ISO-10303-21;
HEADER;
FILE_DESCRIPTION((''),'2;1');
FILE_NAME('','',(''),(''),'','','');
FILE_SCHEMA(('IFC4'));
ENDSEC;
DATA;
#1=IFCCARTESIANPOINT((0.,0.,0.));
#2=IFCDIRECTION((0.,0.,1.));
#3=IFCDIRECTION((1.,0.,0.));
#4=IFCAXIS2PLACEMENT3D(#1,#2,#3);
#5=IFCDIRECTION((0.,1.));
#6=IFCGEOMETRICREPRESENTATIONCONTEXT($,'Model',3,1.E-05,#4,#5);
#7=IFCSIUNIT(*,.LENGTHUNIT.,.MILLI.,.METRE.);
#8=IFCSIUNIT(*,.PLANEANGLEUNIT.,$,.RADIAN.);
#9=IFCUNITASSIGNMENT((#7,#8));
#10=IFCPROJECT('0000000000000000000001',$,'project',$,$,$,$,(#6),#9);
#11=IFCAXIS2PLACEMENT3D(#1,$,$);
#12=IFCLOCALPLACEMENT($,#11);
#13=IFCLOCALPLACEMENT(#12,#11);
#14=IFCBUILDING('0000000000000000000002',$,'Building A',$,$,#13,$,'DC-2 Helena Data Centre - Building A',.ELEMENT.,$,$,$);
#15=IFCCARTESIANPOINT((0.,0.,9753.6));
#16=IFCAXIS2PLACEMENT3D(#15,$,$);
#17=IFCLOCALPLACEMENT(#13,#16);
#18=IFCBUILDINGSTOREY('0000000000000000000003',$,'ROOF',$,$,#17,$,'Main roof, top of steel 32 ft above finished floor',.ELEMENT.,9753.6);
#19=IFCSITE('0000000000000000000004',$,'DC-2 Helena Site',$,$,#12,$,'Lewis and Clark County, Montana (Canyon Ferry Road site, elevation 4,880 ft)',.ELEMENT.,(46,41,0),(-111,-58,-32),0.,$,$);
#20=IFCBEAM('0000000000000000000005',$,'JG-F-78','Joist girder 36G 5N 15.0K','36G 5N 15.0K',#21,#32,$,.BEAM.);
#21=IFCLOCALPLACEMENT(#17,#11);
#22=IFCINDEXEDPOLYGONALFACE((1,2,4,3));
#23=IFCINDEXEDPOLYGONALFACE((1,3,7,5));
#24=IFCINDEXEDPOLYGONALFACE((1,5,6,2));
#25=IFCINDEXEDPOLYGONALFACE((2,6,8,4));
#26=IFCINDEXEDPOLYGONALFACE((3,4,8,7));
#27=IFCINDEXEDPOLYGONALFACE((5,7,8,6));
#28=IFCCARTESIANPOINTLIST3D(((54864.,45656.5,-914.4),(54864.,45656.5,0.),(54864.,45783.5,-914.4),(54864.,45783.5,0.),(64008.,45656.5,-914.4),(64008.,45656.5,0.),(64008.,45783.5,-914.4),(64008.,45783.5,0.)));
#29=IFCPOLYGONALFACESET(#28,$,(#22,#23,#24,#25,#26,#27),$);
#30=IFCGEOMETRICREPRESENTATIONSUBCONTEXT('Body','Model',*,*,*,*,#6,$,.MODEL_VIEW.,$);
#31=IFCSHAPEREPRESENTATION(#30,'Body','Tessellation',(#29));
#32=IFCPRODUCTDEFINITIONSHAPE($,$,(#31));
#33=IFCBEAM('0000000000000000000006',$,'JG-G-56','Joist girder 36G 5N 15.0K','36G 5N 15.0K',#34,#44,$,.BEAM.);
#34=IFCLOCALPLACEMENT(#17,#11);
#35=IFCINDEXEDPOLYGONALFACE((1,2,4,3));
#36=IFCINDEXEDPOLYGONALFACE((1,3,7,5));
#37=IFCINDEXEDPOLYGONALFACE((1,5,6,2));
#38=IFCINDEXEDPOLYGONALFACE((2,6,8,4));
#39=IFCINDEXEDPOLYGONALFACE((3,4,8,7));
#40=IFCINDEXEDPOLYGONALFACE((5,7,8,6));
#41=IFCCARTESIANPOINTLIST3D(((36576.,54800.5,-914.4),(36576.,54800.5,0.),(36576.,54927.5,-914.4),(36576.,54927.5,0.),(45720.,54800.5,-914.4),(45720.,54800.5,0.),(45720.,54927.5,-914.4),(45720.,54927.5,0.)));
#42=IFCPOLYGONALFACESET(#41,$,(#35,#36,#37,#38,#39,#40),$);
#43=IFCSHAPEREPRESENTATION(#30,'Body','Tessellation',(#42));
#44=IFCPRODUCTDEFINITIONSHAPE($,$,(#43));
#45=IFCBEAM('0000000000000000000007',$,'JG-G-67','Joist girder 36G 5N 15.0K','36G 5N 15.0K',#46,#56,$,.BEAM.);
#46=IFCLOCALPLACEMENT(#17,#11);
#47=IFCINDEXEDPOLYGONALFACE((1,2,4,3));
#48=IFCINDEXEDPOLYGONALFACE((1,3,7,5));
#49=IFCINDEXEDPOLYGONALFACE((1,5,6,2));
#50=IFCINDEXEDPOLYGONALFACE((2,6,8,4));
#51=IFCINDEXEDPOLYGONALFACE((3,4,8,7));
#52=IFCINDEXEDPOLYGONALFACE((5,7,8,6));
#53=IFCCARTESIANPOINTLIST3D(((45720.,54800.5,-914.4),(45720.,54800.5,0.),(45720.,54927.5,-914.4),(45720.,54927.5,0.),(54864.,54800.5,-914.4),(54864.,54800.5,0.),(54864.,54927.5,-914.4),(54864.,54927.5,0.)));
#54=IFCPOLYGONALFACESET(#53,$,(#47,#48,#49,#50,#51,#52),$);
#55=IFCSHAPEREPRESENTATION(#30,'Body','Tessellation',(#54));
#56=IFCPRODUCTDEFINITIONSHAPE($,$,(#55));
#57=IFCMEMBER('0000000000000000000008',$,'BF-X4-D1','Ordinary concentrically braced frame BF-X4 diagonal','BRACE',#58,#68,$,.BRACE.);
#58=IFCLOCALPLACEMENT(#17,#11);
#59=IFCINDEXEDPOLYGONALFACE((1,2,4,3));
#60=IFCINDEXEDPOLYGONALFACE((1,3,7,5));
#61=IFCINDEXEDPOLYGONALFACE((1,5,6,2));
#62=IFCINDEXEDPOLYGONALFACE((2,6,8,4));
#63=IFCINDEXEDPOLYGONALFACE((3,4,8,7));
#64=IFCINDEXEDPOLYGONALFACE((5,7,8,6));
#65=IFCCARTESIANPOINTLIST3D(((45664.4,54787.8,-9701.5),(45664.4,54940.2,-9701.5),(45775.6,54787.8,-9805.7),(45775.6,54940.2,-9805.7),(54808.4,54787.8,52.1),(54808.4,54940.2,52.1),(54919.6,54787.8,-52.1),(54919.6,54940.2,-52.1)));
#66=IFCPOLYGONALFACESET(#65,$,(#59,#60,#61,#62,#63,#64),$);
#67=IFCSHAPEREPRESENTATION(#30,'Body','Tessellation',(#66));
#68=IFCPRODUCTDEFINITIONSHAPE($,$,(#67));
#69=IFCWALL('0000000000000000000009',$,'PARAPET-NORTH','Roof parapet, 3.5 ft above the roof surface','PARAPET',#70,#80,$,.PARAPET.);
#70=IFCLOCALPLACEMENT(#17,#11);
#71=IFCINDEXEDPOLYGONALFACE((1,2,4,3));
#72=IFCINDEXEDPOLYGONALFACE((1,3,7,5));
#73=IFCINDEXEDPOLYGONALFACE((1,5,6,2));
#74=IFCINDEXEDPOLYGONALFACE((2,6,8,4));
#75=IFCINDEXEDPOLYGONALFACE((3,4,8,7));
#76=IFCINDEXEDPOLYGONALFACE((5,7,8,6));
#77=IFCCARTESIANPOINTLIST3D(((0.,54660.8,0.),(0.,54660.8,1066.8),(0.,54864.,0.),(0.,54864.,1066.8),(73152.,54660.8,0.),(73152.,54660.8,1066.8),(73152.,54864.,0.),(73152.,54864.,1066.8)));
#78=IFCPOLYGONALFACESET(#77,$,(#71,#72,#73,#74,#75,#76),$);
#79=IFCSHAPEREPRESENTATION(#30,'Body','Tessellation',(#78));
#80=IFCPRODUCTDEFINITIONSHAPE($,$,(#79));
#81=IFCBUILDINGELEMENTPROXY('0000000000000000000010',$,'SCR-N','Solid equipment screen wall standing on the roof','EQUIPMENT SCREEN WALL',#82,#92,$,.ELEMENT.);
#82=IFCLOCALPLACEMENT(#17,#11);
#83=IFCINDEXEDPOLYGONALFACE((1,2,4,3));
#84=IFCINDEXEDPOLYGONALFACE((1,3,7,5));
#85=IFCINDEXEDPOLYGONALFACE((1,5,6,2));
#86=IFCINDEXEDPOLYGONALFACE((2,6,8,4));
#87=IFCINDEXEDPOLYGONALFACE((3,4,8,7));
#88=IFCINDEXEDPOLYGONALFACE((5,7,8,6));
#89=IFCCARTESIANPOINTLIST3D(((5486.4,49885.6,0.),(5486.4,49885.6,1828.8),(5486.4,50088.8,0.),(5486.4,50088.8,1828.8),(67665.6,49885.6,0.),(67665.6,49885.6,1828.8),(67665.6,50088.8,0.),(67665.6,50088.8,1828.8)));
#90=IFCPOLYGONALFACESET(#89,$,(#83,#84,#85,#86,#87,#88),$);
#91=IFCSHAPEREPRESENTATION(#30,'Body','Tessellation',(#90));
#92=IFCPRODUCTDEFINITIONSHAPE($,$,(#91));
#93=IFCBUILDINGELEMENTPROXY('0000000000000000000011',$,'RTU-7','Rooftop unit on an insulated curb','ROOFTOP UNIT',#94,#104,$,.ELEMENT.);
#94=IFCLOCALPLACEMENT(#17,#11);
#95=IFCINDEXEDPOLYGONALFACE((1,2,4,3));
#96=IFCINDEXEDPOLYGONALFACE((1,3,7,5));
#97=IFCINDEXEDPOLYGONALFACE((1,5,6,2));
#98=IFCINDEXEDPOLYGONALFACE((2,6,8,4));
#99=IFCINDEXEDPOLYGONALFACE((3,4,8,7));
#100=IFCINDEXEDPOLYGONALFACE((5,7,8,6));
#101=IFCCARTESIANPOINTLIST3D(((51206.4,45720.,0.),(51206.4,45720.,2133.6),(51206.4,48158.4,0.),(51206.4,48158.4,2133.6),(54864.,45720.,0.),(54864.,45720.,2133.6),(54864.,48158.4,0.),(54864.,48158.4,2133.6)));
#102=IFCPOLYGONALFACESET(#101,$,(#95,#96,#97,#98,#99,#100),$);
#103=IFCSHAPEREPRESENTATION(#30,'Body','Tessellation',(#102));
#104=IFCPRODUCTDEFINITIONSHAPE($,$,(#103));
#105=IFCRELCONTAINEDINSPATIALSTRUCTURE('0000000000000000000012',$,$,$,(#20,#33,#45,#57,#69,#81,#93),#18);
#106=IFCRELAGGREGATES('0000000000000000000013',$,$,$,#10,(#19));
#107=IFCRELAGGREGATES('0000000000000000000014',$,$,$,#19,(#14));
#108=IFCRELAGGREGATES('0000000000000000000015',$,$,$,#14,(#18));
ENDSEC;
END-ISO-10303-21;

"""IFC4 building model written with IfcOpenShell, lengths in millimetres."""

from ifc_helpers import new_model, si_unit, direction, frame, origin, origin_with_axes, origin_2d, place, context, subcontext, project, spatial, rectangle, extrude, element, save


model = new_model("IFC4")

# Units and contexts
model_context = context("Model", 3, precision=1e-05, world=origin_with_axes(), true_north=direction((0.0, 1.0)))
body_context = subcontext(model_context, "Body", "Model", "MODEL_VIEW")
ifc_project = project(units=[si_unit("LENGTHUNIT", "METRE", prefix="MILLI"), si_unit("PLANEANGLEUNIT", "RADIAN")], contexts=[model_context])

# Site, building, storey
site_placement = place(None, origin())
site = spatial("IfcSite", under=ifc_project, at=site_placement, Name="DC-2 Helena Site", LongName="Lewis and Clark County, Montana (Canyon Ferry Road site, elevation 4,880 ft)", CompositionType="ELEMENT", RefLatitude=(46, 41, 0), RefLongitude=(-111, -58, -32), RefElevation=0.0)
building_placement = place(site_placement, origin())
building = spatial("IfcBuilding", under=site, at=building_placement, Name="Building A", LongName="DC-2 Helena Data Centre - Building A", CompositionType="ELEMENT")
storey_placement = place(building_placement, frame((0.0, 0.0, 9753.6)))
storey = spatial("IfcBuildingStorey", under=building, at=storey_placement, Name="ROOF", LongName="Main roof, top of steel 32 ft above finished floor", CompositionType="ELEMENT", Elevation=9753.6)

# Shared definitions
placement_1 = place(storey_placement, frame((45720.0, 54864.0, -9753.6)))

# Beams
placement_2 = place(storey_placement, frame((54864.0, 45720.0, 0.0)))
element("IfcBeam", 1, at=placement_2, inside=storey, Name="JG-F-78", Description="Joist girder 36G 5N 15.0K", ObjectType="36G 5N 15.0K", PredefinedType="BEAM", context=body_context, shape_type="SweptSolid", body=[
    extrude(rectangle(XDim=127.0, YDim=914.4, at=origin_2d()), frame((0.0, 0.0, -457.2), z_axis=(1.0, 0.0, 0.0), x_axis=(0.0, 1.0, 0.0)), (0.0, 0.0, 1.0), 9144.0),
])
for number, where, name in (
    (2, (36576.0, 54864.0, 0.0), "JG-G-56"),
    (3, (45720.0, 54864.0, 0.0), "JG-G-67"),
):
    element("IfcBeam", number, at=place(storey_placement, frame(where)), inside=storey, Name=name, Description="Joist girder 36G 5N 15.0K", ObjectType="36G 5N 15.0K", PredefinedType="BEAM", context=body_context, shape_type="SweptSolid", body=[
        extrude(rectangle(XDim=127.0, YDim=914.4, at=origin_2d()), frame((0.0, 0.0, -457.2), z_axis=(1.0, 0.0, 0.0), x_axis=(0.0, 1.0, 0.0)), (0.0, 0.0, 1.0), 9144.0),
    ])

# Member
element("IfcMember", 4, at=placement_1, inside=storey, Name="BF-X4-D1", Description="Ordinary concentrically braced frame BF-X4 diagonal", ObjectType="BRACE", PredefinedType="BRACE", context=body_context, shape_type="SweptSolid", body=[
    extrude(rectangle(XDim=152.4, YDim=152.4, at=origin_2d()), frame((0.0, 0.0, 0.0), z_axis=(0.683941, 0.0, 0.729537), x_axis=(0.0, 1.0, 0.0)), (0.0, 0.0, 1.0), 13369.6),
])

# Wall
wall_placement = place(storey_placement, frame((36576.0, 54762.4, 0.0)))
element("IfcWall", 5, at=wall_placement, inside=storey, Name="PARAPET-NORTH", Description="Roof parapet, 3.5 ft above the roof surface", ObjectType="PARAPET", PredefinedType="PARAPET", context=body_context, shape_type="SweptSolid", body=[
    extrude(rectangle(XDim=73152.0, YDim=203.2, at=origin_2d()), origin(), (0.0, 0.0, 1.0), 1066.8),
])

# Building element proxies
proxy_1_placement = place(storey_placement, frame((36576.0, 49987.2, 0.0)))
element("IfcBuildingElementProxy", 6, at=proxy_1_placement, inside=storey, Name="SCR-N", Description="Solid equipment screen wall standing on the roof", ObjectType="EQUIPMENT SCREEN WALL", PredefinedType="ELEMENT", context=body_context, shape_type="SweptSolid", body=[
    extrude(rectangle(XDim=62179.2, YDim=203.2, at=origin_2d()), origin(), (0.0, 0.0, 1.0), 1828.8),
])
proxy_2_placement = place(storey_placement, frame((53035.2, 46939.2, 0.0)))
element("IfcBuildingElementProxy", 7, at=proxy_2_placement, inside=storey, Name="RTU-7", Description="Rooftop unit on an insulated curb", ObjectType="ROOFTOP UNIT", PredefinedType="ELEMENT", context=body_context, shape_type="SweptSolid", body=[
    extrude(rectangle(XDim=3657.6, YDim=2438.4, at=origin_2d()), origin(), (0.0, 0.0, 1.0), 2133.6),
])

save(model, "model.ifc")
